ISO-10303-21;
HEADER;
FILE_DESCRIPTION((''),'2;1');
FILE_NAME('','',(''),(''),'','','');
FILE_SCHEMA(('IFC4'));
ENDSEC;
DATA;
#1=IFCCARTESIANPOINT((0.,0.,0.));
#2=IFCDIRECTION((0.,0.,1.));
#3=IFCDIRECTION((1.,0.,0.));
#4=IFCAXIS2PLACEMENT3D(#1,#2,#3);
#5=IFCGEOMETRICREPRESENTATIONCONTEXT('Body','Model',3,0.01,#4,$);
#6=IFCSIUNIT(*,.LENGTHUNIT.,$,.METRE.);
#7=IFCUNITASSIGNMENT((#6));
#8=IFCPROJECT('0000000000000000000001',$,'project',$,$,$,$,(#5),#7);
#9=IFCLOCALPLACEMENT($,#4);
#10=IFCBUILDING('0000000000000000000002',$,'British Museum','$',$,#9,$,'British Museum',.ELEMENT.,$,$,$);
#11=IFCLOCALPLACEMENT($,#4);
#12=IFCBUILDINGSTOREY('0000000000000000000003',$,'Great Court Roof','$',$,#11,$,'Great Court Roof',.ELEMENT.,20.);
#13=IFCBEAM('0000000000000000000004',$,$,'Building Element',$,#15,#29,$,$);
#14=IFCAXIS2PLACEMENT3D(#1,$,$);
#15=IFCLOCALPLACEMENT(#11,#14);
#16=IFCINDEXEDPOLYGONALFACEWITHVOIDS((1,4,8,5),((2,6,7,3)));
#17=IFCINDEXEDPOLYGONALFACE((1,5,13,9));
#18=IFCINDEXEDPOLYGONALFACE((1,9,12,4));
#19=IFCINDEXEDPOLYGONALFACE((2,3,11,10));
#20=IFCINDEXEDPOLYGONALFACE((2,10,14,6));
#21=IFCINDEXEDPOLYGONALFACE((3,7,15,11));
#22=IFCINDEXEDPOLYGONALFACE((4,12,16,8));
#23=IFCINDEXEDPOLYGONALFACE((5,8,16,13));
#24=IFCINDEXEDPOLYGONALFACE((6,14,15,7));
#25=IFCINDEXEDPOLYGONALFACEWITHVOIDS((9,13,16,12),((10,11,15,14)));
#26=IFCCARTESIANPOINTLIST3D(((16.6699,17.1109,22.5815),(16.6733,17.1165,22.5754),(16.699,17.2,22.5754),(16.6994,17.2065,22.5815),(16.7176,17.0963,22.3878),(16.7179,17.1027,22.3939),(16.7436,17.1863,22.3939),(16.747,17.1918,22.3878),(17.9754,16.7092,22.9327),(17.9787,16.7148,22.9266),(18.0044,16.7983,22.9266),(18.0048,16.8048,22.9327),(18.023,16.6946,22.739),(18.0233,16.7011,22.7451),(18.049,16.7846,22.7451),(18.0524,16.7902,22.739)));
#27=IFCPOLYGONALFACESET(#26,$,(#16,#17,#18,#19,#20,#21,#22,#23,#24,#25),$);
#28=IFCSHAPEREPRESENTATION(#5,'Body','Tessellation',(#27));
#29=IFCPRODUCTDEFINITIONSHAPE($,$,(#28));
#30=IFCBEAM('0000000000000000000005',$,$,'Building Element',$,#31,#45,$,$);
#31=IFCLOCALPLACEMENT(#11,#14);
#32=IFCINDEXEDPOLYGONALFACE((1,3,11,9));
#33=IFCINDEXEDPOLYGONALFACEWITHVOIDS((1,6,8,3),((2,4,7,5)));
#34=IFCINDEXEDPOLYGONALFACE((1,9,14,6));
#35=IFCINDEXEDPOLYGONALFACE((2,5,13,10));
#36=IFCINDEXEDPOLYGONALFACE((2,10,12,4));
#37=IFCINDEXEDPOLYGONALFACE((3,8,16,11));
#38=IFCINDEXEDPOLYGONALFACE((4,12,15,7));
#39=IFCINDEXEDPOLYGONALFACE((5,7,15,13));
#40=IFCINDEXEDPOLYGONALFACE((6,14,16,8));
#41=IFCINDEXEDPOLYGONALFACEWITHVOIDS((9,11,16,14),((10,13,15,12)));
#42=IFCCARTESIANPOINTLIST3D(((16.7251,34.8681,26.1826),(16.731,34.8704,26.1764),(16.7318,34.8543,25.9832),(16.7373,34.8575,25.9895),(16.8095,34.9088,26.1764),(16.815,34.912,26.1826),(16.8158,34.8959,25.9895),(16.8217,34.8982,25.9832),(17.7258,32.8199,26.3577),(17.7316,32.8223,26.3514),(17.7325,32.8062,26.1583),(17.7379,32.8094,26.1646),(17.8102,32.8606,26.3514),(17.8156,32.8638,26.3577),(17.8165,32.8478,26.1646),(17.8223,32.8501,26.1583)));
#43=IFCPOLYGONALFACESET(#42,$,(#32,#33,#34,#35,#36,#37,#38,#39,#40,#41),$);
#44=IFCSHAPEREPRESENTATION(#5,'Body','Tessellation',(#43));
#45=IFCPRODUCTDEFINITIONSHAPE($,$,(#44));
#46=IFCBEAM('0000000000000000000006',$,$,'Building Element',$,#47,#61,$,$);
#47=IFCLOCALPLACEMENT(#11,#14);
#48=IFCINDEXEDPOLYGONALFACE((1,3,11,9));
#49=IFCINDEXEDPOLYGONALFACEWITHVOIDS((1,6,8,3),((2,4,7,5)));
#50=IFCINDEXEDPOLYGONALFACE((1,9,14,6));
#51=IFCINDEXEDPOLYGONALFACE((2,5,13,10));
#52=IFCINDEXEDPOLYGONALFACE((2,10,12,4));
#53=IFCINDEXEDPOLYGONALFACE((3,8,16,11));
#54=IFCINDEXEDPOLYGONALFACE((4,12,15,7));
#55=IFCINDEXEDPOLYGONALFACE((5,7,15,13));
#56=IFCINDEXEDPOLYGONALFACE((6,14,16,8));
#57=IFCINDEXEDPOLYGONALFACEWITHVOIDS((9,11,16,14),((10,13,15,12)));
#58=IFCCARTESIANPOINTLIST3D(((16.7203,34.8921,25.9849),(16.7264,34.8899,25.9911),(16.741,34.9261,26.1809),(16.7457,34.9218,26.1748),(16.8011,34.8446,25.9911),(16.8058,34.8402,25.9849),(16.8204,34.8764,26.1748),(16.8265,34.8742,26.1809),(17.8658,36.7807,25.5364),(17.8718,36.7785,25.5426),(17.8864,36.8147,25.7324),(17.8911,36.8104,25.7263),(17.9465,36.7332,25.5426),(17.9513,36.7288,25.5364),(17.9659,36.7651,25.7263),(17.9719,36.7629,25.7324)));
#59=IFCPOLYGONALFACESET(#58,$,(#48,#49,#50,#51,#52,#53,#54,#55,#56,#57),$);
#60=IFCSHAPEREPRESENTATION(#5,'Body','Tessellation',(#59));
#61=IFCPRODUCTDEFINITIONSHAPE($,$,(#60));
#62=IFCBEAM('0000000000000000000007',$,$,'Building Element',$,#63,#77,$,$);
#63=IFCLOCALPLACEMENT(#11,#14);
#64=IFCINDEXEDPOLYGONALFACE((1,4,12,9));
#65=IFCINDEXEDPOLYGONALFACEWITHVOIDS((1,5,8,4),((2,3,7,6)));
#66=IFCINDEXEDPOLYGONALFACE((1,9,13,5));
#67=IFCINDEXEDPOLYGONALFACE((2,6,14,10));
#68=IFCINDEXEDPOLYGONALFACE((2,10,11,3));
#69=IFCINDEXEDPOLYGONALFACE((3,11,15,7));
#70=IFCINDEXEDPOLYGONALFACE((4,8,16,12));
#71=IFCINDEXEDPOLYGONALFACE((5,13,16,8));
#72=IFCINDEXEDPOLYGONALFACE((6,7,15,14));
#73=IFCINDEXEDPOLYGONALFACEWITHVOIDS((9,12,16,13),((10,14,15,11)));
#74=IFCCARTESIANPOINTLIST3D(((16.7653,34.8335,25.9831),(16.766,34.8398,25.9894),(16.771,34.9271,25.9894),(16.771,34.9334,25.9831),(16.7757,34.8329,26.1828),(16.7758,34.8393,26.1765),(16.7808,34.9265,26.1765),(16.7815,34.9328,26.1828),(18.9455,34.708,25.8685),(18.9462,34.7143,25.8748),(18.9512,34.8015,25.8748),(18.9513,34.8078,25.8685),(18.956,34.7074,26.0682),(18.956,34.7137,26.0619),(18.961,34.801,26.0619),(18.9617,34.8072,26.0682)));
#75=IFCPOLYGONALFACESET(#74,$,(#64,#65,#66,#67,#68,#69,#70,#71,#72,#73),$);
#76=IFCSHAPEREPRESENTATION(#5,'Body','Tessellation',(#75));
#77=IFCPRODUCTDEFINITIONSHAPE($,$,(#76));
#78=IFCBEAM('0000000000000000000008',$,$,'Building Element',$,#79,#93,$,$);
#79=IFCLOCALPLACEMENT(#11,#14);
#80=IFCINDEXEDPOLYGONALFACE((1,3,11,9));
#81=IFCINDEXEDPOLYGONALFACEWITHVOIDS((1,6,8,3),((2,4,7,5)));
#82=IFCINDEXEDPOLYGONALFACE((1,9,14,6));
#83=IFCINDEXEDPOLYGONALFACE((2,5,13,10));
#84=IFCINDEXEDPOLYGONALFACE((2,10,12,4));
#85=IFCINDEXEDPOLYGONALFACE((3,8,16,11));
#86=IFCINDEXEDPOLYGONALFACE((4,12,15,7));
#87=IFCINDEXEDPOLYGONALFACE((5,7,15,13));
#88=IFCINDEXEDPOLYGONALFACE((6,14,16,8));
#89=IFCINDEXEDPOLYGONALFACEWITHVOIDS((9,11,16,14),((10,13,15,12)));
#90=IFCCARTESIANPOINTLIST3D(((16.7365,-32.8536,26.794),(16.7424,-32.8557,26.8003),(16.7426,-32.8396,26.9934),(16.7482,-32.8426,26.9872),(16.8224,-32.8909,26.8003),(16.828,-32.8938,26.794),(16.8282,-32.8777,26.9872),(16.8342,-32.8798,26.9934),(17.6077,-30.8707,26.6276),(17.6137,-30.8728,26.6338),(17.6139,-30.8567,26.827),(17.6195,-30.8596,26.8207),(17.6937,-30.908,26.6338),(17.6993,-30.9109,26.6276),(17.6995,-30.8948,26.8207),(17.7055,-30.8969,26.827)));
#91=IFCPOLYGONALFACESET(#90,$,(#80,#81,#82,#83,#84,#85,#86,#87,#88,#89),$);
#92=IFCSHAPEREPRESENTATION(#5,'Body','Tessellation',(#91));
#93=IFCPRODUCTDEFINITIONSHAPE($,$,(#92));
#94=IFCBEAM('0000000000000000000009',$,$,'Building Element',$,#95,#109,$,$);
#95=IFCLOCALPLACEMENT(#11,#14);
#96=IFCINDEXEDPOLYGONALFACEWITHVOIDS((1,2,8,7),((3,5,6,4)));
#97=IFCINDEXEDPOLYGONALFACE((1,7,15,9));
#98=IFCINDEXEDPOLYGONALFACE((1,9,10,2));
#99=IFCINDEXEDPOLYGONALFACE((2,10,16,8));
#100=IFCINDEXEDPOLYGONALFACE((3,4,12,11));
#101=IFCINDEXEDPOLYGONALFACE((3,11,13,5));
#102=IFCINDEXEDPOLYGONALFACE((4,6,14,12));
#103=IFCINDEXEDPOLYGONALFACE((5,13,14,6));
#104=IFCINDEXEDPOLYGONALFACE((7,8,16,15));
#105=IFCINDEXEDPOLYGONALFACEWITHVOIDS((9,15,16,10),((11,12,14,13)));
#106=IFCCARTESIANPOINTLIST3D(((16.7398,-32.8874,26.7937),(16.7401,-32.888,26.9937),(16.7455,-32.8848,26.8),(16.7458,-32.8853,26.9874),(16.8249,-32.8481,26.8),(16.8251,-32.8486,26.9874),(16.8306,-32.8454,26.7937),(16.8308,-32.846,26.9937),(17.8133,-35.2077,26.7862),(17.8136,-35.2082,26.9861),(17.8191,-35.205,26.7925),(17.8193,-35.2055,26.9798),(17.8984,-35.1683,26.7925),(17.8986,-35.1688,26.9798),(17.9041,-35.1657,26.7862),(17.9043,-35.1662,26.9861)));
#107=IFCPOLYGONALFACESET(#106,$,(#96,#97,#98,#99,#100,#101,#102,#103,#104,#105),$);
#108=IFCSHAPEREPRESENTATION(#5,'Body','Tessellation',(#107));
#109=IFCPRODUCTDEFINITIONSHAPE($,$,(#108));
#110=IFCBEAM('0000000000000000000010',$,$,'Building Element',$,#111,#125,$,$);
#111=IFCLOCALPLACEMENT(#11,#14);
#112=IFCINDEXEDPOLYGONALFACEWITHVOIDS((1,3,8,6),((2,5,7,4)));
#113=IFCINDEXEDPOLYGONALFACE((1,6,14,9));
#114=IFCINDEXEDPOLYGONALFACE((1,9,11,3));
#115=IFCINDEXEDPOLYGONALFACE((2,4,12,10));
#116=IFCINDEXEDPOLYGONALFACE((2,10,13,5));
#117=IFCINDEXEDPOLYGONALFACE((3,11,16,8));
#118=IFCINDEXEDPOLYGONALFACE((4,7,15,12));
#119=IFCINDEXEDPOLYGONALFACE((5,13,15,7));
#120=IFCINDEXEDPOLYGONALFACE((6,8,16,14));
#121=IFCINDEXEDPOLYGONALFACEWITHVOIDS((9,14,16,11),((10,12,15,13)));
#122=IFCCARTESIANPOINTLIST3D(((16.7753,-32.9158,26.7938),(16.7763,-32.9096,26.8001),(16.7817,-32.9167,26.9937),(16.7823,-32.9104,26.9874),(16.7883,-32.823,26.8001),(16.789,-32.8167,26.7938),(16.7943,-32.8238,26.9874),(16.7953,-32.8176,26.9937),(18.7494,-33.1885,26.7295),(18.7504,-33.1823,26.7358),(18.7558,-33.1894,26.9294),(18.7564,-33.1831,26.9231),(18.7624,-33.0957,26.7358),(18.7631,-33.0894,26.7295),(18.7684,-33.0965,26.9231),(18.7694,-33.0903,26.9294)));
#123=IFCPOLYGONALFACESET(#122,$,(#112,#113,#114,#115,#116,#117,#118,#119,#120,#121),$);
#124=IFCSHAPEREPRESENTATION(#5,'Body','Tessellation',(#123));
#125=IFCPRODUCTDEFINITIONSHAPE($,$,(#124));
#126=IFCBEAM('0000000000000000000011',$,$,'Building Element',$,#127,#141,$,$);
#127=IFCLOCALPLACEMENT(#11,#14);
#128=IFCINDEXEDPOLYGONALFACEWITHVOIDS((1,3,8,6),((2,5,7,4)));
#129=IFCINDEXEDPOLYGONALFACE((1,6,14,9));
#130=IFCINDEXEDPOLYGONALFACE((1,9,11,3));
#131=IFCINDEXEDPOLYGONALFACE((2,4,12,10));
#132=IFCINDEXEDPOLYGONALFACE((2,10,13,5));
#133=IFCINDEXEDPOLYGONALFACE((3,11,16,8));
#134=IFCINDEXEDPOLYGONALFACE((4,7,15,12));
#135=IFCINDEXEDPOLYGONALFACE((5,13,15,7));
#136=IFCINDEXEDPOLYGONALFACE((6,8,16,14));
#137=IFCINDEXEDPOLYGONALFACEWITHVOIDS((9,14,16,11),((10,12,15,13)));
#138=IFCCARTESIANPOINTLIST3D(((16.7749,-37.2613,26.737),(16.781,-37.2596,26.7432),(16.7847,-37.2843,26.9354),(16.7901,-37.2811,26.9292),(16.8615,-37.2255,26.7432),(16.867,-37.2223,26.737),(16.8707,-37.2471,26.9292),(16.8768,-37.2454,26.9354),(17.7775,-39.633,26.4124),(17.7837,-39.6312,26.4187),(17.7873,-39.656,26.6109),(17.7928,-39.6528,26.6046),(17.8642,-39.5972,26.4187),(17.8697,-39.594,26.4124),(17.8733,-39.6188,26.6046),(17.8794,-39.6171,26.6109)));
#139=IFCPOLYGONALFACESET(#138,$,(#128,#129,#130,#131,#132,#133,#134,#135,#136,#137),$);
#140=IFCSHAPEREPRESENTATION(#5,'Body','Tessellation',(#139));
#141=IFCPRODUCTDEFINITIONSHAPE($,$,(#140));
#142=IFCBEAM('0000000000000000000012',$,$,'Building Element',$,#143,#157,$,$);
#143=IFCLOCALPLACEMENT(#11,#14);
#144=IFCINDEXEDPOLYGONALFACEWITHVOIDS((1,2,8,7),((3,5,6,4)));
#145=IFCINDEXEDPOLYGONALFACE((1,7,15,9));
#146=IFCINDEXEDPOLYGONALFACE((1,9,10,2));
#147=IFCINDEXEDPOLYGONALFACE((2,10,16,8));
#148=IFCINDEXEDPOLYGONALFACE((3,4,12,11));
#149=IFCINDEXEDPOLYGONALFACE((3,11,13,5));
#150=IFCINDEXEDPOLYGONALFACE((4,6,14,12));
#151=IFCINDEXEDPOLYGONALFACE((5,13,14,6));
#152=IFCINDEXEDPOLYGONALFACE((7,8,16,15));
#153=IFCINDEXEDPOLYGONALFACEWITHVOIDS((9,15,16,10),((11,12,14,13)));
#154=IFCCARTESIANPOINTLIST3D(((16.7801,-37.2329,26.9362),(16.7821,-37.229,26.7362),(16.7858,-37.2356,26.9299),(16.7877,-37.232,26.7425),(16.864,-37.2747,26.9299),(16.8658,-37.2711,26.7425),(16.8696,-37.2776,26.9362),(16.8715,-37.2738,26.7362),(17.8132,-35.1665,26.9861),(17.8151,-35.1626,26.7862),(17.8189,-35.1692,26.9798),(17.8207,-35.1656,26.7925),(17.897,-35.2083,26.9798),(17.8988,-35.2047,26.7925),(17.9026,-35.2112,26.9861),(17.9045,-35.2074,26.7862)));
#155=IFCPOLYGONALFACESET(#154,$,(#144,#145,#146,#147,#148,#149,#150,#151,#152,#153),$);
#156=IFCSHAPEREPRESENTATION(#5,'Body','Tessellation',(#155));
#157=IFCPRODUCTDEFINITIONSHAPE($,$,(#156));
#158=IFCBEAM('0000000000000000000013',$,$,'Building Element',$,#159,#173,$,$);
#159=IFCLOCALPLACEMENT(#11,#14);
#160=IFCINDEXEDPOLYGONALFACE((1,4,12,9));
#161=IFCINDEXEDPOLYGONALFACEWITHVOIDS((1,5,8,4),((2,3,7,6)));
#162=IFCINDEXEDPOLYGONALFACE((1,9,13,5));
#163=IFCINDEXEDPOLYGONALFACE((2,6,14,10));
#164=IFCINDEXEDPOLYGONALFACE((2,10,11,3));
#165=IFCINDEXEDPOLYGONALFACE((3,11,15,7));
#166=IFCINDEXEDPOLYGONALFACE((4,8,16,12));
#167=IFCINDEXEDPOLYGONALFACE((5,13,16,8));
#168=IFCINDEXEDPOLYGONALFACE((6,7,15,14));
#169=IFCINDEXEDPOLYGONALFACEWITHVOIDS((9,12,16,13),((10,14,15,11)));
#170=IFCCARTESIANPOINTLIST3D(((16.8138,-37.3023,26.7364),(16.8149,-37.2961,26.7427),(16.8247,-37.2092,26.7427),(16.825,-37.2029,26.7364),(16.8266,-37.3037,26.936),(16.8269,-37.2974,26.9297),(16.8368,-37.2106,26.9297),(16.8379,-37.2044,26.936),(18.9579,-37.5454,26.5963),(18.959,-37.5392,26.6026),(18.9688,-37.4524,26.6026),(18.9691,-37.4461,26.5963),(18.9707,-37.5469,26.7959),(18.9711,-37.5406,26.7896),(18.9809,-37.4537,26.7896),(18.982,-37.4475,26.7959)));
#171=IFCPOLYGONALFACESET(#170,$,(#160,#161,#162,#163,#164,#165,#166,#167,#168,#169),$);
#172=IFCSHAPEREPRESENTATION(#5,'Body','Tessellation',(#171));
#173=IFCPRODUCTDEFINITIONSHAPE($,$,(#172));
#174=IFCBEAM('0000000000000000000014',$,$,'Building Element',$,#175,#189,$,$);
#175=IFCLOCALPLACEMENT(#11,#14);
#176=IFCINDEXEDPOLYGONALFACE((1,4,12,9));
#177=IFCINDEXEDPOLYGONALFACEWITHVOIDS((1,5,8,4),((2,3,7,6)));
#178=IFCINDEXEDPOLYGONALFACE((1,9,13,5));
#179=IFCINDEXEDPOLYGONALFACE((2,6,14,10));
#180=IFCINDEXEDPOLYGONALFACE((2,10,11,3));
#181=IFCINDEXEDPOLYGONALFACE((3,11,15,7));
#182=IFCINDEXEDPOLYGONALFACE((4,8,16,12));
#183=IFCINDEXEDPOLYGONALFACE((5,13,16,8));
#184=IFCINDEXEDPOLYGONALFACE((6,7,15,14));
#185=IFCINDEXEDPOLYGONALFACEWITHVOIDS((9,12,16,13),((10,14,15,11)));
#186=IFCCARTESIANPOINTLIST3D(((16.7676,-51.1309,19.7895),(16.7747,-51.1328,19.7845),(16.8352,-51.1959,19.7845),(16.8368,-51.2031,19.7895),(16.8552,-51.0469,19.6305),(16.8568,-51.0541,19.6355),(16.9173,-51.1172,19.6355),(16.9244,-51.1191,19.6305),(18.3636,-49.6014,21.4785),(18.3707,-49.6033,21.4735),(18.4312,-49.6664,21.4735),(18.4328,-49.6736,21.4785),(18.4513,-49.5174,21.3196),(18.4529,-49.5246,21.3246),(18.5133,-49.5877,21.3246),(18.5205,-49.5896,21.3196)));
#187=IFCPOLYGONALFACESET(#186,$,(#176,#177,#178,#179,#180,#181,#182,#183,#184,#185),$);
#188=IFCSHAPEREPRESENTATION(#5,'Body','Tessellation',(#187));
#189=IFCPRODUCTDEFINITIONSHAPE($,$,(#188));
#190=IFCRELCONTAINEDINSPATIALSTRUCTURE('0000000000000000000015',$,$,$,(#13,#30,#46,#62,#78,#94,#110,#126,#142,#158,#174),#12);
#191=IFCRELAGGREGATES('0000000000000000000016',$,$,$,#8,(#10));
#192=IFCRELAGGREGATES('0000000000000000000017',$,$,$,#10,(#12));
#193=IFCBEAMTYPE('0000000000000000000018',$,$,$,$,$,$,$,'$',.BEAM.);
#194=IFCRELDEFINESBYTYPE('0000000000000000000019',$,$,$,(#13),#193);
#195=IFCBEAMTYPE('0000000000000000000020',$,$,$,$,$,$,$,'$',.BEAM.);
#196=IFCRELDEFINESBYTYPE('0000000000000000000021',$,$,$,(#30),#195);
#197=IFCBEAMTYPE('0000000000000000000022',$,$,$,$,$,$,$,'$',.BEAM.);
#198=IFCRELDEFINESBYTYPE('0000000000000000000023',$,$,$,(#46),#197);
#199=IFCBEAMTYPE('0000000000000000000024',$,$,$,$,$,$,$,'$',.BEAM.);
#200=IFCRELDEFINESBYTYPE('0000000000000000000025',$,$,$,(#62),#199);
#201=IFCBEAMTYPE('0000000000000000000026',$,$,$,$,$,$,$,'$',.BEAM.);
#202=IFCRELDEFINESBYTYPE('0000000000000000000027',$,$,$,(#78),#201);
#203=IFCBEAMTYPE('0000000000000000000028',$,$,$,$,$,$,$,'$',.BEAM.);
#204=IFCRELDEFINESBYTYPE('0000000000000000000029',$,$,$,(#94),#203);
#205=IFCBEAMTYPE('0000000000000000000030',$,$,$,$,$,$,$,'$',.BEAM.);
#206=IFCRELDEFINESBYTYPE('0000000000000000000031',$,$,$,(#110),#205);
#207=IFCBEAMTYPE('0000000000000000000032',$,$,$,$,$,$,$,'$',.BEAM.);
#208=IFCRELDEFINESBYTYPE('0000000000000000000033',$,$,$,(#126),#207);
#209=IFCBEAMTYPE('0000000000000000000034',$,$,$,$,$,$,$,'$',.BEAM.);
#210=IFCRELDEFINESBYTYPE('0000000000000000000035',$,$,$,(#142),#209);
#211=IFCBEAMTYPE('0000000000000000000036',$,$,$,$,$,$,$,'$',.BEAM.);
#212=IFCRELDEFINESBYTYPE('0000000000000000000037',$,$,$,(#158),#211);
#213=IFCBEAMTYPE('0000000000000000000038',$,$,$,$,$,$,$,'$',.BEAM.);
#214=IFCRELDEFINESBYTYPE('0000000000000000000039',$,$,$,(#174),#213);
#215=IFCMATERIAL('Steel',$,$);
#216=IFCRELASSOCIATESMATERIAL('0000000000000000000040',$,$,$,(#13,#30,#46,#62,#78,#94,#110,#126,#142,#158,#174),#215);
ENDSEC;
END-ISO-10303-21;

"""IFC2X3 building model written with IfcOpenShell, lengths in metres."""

from ifc_helpers import new_model, si_unit, frame, origin_with_axes, origin_2d, place, context, project, spatial, hollow_rectangle, extrude, material, type_object, element, save


model = new_model("IFC2X3")

# Units and contexts
model_context = context("Model", 3, precision=0.01, world=origin_with_axes(), identifier="Body")
ifc_project = project(units=[si_unit("LENGTHUNIT", "METRE")], contexts=[model_context])

# Building, storey
building_placement = place(None, origin_with_axes())
building = spatial("IfcBuilding", under=ifc_project, at=building_placement, Name="British Museum", Description="$", LongName="British Museum", CompositionType="ELEMENT")
storey_placement = place(None, origin_with_axes())
storey = spatial("IfcBuildingStorey", under=building, at=storey_placement, Name="Great Court Roof", Description="$", LongName="Great Court Roof", CompositionType="ELEMENT", Elevation=20.0)

# Beams
ifc_material = material(Name="Steel")
beam_type_1 = type_object("IfcBeamType", ElementType="$", PredefinedType="BEAM")
beam_1_placement = place(None, origin_with_axes())
element("IfcBeam", 1, at=beam_1_placement, inside=storey, type_object=beam_type_1, material=ifc_material, Description="Building Element", context=model_context, shape_type="SweptSolid", body=[
    extrude(hollow_rectangle(XDim=0.1, YDim=0.2, WallThickness=0.0063, InnerFilletRadius=0.0, OuterFilletRadius=0.0, at=origin_2d()), frame((16.7085, 17.1514, 22.4846), z_axis=(0.925668, -0.284824, 0.249025), x_axis=(0.294088, 0.955778, 0.0)), (0.0, 0.0, 1.0), 1.4103),
])
beam_type_2 = type_object("IfcBeamType", ElementType="$", PredefinedType="BEAM")
beam_2_placement = place(None, origin_with_axes())
element("IfcBeam", 2, at=beam_2_placement, inside=storey, type_object=beam_type_2, material=ifc_material, Description="Building Element", context=model_context, shape_type="SweptSolid", body=[
    extrude(hollow_rectangle(XDim=0.1, YDim=0.2, WallThickness=0.0063, InnerFilletRadius=0.0, OuterFilletRadius=0.0, at=origin_2d()), frame((16.7734, 34.8832, 26.0829), z_axis=(0.437693, -0.895858, 0.076573), x_axis=(0.898496, 0.438982, 0.0)), (0.0, 0.0, 1.0), 2.2862),
])
beam_type_3 = type_object("IfcBeamType", ElementType="$", PredefinedType="BEAM")
beam_3_placement = place(None, origin_with_axes())
element("IfcBeam", 3, at=beam_3_placement, inside=storey, type_object=beam_type_3, material=ifc_material, Description="Building Element", context=model_context, shape_type="SweptSolid", body=[
    extrude(hollow_rectangle(XDim=0.1, YDim=0.2, WallThickness=0.0063, InnerFilletRadius=0.0, OuterFilletRadius=0.0, at=origin_2d()), frame((16.7734, 34.8832, 26.0829), z_axis=(0.508208, 0.837933, -0.198982), x_axis=(-0.855031, 0.518578, 0.0)), (0.0, 0.0, 1.0), 2.2539),
])
beam_type_4 = type_object("IfcBeamType", ElementType="$", PredefinedType="BEAM")
beam_4_placement = place(None, origin_with_axes())
element("IfcBeam", 4, at=beam_4_placement, inside=storey, type_object=beam_type_4, material=ifc_material, Description="Building Element", context=model_context, shape_type="SweptSolid", body=[
    extrude(hollow_rectangle(XDim=0.1, YDim=0.2, WallThickness=0.0063, InnerFilletRadius=0.0, OuterFilletRadius=0.0, at=origin_2d()), frame((16.7734, 34.8832, 26.0829), z_axis=(0.996975, -0.057408, -0.052403), x_axis=(0.057487, 0.998346, 0.0)), (0.0, 0.0, 1.0), 2.1868),
])
beam_type_5 = type_object("IfcBeamType", ElementType="$", PredefinedType="BEAM")
beam_5_placement = place(None, origin_with_axes())
element("IfcBeam", 5, at=beam_5_placement, inside=storey, type_object=beam_type_5, material=ifc_material, Description="Building Element", context=model_context, shape_type="SweptSolid", body=[
    extrude(hollow_rectangle(XDim=0.1, YDim=0.2, WallThickness=0.0063, InnerFilletRadius=0.0, OuterFilletRadius=0.0, at=origin_2d()), frame((16.7853, -32.8667, 26.8937), z_axis=(0.401094, 0.912825, -0.076635), x_axis=(-0.915518, 0.402277, 0.0)), (0.0, 0.0, 1.0), 2.1723),
])
beam_type_6 = type_object("IfcBeamType", ElementType="$", PredefinedType="BEAM")
beam_6_placement = place(None, origin_with_axes())
element("IfcBeam", 6, at=beam_6_placement, inside=storey, type_object=beam_type_6, material=ifc_material, Description="Building Element", context=model_context, shape_type="SweptSolid", body=[
    extrude(hollow_rectangle(XDim=0.1, YDim=0.2, WallThickness=0.0063, InnerFilletRadius=0.0, OuterFilletRadius=0.0, at=origin_2d()), frame((16.7853, -32.8667, 26.8937), z_axis=(0.419916, -0.907558, -0.002966), x_axis=(0.907562, 0.419918, 0.0)), (0.0, 0.0, 1.0), 2.5565),
])
beam_type_7 = type_object("IfcBeamType", ElementType="$", PredefinedType="BEAM")
beam_7_placement = place(None, origin_with_axes())
element("IfcBeam", 7, at=beam_7_placement, inside=storey, type_object=beam_type_7, material=ifc_material, Description="Building Element", context=model_context, shape_type="SweptSolid", body=[
    extrude(hollow_rectangle(XDim=0.1, YDim=0.2, WallThickness=0.0063, InnerFilletRadius=0.0, OuterFilletRadius=0.0, at=origin_2d()), frame((16.7853, -32.8667, 26.8937), z_axis=(0.99008, -0.136758, -0.032229), x_axis=(0.136829, 0.990595, 0.0)), (0.0, 0.0, 1.0), 1.9939),
])
beam_type_8 = type_object("IfcBeamType", ElementType="$", PredefinedType="BEAM")
beam_8_placement = place(None, origin_with_axes())
element("IfcBeam", 8, at=beam_8_placement, inside=storey, type_object=beam_type_8, material=ifc_material, Description="Building Element", context=model_context, shape_type="SweptSolid", body=[
    extrude(hollow_rectangle(XDim=0.1, YDim=0.2, WallThickness=0.0063, InnerFilletRadius=0.0, OuterFilletRadius=0.0, at=origin_2d()), frame((16.8258, -37.2533, 26.8362), z_axis=(0.386328, -0.913845, -0.125048), x_axis=(0.921075, 0.389385, 0.0)), (0.0, 0.0, 1.0), 2.5953),
])
beam_type_9 = type_object("IfcBeamType", ElementType="$", PredefinedType="BEAM")
beam_9_placement = place(None, origin_with_axes())
element("IfcBeam", 9, at=beam_9_placement, inside=storey, type_object=beam_type_9, material=ifc_material, Description="Building Element", context=model_context, shape_type="SweptSolid", body=[
    extrude(hollow_rectangle(XDim=0.1, YDim=0.2, WallThickness=0.0063, InnerFilletRadius=0.0, OuterFilletRadius=0.0, at=origin_2d()), frame((16.8258, -37.2533, 26.8362), z_axis=(0.447042, 0.894252, 0.021619), x_axis=(-0.894461, 0.447146, 0.0)), (0.0, 0.0, 1.0), 2.3108),
])
beam_type_10 = type_object("IfcBeamType", ElementType="$", PredefinedType="BEAM")
beam_10_placement = place(None, origin_with_axes())
element("IfcBeam", 10, at=beam_10_placement, inside=storey, type_object=beam_type_10, material=ifc_material, Description="Building Element", context=model_context, shape_type="SweptSolid", body=[
    extrude(hollow_rectangle(XDim=0.1, YDim=0.2, WallThickness=0.0063, InnerFilletRadius=0.0, OuterFilletRadius=0.0, at=origin_2d()), frame((16.8258, -37.2533, 26.8362), z_axis=(0.991543, -0.112443, -0.064802), x_axis=(0.112679, 0.993631, 0.0)), (0.0, 0.0, 1.0), 2.1624),
])
beam_type_11 = type_object("IfcBeamType", ElementType="$", PredefinedType="BEAM")
beam_11_placement = place(None, origin_with_axes())
element("IfcBeam", 11, at=beam_11_placement, inside=storey, type_object=beam_type_11, material=ifc_material, Description="Building Element", context=model_context, shape_type="SweptSolid", body=[
    extrude(hollow_rectangle(XDim=0.1, YDim=0.2, WallThickness=0.0063, InnerFilletRadius=0.0, OuterFilletRadius=0.0, at=origin_2d()), frame((16.846, -51.125, 19.71), z_axis=(0.573693, 0.549776, 0.607143), x_axis=(-0.691897, 0.721996, 0.0)), (0.0, 0.0, 1.0), 2.782),
])

save(model, "model.ifc")
